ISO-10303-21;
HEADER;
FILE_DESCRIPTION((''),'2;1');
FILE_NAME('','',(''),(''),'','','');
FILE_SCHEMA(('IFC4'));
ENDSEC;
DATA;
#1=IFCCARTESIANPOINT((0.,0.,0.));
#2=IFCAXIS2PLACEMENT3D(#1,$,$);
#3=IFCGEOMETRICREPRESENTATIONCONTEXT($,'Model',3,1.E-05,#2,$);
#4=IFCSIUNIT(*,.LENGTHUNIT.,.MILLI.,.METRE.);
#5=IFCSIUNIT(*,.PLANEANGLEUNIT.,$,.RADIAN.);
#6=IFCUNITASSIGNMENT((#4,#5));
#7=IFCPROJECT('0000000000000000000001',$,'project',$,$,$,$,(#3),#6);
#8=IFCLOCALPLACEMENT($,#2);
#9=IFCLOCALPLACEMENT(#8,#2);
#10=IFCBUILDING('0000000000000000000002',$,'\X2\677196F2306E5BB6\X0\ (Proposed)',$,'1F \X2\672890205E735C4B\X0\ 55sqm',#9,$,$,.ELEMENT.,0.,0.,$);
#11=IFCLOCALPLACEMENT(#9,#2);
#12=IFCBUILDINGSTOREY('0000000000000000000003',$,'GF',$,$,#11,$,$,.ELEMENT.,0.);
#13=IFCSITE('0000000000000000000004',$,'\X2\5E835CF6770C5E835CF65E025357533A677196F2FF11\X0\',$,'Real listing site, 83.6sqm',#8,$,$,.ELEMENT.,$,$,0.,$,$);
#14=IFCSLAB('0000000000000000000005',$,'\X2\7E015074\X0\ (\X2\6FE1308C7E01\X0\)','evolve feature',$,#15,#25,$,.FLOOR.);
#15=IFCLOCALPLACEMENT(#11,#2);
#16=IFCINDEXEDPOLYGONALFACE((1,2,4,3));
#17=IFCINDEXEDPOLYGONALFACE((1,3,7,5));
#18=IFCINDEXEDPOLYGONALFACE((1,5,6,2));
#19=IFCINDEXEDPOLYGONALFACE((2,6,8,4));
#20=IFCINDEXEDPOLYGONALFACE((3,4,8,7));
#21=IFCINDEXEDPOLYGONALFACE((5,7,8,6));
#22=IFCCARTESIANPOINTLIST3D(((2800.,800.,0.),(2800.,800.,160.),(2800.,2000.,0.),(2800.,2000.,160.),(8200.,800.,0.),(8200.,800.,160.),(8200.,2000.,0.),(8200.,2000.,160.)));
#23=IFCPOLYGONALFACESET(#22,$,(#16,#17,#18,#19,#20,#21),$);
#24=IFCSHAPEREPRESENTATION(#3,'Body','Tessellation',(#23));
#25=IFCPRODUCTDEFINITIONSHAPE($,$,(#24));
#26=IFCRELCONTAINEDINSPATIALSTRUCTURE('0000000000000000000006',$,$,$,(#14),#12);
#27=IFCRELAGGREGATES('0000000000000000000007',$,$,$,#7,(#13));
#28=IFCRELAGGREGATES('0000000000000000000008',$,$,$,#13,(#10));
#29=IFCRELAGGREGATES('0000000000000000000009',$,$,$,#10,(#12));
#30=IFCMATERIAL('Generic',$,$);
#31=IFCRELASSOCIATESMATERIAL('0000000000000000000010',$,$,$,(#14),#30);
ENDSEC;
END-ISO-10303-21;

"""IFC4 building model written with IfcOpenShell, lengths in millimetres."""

from ifc_helpers import new_model, si_unit, frame, frame_2d, origin, place, context, project, spatial, rectangle, extrude, material, element, save


model = new_model("IFC4")

# Units and contexts
model_context = context("Model", 3, precision=1e-05, world=origin())
ifc_project = project(units=[si_unit("LENGTHUNIT", "METRE", prefix="MILLI"), si_unit("PLANEANGLEUNIT", "RADIAN")], contexts=[model_context])

# Site, building, storey
site_placement = place(None, origin())
site = spatial("IfcSite", under=ifc_project, at=site_placement, Name="広島県広島市南区東雲１", ObjectType="Real listing site, 83.6sqm", CompositionType="ELEMENT", RefElevation=0.0)
building_placement = place(site_placement, origin())
building = spatial("IfcBuilding", under=site, at=building_placement, Name="東雲の家 (Proposed)", ObjectType="1F 木造平屋 55sqm", CompositionType="ELEMENT", ElevationOfRefHeight=0.0, ElevationOfTerrain=0.0)
storey_placement = place(building_placement, origin())
storey = spatial("IfcBuildingStorey", under=building, at=storey_placement, Name="GF", CompositionType="ELEMENT", Elevation=0.0)

# Slab
ifc_material_1 = material(Name="Generic")
slab_1_placement = place(storey_placement, frame((1400.0, 400.0, 0.0)))
element("IfcSlab", 1, at=slab_1_placement, inside=storey, material=ifc_material_1, Name="縁側 (濡れ縁)", Description="evolve feature", PredefinedType="FLOOR", context=model_context, shape_type="SweptSolid", body=[
    extrude(rectangle(XDim=5400.0, YDim=1200.0, at=frame_2d((2700.0, 600.0))), frame((1400.0, 400.0, 0.0)), (0.0, 0.0, 1.0), 160.0),
])

save(model, "model.ifc")
